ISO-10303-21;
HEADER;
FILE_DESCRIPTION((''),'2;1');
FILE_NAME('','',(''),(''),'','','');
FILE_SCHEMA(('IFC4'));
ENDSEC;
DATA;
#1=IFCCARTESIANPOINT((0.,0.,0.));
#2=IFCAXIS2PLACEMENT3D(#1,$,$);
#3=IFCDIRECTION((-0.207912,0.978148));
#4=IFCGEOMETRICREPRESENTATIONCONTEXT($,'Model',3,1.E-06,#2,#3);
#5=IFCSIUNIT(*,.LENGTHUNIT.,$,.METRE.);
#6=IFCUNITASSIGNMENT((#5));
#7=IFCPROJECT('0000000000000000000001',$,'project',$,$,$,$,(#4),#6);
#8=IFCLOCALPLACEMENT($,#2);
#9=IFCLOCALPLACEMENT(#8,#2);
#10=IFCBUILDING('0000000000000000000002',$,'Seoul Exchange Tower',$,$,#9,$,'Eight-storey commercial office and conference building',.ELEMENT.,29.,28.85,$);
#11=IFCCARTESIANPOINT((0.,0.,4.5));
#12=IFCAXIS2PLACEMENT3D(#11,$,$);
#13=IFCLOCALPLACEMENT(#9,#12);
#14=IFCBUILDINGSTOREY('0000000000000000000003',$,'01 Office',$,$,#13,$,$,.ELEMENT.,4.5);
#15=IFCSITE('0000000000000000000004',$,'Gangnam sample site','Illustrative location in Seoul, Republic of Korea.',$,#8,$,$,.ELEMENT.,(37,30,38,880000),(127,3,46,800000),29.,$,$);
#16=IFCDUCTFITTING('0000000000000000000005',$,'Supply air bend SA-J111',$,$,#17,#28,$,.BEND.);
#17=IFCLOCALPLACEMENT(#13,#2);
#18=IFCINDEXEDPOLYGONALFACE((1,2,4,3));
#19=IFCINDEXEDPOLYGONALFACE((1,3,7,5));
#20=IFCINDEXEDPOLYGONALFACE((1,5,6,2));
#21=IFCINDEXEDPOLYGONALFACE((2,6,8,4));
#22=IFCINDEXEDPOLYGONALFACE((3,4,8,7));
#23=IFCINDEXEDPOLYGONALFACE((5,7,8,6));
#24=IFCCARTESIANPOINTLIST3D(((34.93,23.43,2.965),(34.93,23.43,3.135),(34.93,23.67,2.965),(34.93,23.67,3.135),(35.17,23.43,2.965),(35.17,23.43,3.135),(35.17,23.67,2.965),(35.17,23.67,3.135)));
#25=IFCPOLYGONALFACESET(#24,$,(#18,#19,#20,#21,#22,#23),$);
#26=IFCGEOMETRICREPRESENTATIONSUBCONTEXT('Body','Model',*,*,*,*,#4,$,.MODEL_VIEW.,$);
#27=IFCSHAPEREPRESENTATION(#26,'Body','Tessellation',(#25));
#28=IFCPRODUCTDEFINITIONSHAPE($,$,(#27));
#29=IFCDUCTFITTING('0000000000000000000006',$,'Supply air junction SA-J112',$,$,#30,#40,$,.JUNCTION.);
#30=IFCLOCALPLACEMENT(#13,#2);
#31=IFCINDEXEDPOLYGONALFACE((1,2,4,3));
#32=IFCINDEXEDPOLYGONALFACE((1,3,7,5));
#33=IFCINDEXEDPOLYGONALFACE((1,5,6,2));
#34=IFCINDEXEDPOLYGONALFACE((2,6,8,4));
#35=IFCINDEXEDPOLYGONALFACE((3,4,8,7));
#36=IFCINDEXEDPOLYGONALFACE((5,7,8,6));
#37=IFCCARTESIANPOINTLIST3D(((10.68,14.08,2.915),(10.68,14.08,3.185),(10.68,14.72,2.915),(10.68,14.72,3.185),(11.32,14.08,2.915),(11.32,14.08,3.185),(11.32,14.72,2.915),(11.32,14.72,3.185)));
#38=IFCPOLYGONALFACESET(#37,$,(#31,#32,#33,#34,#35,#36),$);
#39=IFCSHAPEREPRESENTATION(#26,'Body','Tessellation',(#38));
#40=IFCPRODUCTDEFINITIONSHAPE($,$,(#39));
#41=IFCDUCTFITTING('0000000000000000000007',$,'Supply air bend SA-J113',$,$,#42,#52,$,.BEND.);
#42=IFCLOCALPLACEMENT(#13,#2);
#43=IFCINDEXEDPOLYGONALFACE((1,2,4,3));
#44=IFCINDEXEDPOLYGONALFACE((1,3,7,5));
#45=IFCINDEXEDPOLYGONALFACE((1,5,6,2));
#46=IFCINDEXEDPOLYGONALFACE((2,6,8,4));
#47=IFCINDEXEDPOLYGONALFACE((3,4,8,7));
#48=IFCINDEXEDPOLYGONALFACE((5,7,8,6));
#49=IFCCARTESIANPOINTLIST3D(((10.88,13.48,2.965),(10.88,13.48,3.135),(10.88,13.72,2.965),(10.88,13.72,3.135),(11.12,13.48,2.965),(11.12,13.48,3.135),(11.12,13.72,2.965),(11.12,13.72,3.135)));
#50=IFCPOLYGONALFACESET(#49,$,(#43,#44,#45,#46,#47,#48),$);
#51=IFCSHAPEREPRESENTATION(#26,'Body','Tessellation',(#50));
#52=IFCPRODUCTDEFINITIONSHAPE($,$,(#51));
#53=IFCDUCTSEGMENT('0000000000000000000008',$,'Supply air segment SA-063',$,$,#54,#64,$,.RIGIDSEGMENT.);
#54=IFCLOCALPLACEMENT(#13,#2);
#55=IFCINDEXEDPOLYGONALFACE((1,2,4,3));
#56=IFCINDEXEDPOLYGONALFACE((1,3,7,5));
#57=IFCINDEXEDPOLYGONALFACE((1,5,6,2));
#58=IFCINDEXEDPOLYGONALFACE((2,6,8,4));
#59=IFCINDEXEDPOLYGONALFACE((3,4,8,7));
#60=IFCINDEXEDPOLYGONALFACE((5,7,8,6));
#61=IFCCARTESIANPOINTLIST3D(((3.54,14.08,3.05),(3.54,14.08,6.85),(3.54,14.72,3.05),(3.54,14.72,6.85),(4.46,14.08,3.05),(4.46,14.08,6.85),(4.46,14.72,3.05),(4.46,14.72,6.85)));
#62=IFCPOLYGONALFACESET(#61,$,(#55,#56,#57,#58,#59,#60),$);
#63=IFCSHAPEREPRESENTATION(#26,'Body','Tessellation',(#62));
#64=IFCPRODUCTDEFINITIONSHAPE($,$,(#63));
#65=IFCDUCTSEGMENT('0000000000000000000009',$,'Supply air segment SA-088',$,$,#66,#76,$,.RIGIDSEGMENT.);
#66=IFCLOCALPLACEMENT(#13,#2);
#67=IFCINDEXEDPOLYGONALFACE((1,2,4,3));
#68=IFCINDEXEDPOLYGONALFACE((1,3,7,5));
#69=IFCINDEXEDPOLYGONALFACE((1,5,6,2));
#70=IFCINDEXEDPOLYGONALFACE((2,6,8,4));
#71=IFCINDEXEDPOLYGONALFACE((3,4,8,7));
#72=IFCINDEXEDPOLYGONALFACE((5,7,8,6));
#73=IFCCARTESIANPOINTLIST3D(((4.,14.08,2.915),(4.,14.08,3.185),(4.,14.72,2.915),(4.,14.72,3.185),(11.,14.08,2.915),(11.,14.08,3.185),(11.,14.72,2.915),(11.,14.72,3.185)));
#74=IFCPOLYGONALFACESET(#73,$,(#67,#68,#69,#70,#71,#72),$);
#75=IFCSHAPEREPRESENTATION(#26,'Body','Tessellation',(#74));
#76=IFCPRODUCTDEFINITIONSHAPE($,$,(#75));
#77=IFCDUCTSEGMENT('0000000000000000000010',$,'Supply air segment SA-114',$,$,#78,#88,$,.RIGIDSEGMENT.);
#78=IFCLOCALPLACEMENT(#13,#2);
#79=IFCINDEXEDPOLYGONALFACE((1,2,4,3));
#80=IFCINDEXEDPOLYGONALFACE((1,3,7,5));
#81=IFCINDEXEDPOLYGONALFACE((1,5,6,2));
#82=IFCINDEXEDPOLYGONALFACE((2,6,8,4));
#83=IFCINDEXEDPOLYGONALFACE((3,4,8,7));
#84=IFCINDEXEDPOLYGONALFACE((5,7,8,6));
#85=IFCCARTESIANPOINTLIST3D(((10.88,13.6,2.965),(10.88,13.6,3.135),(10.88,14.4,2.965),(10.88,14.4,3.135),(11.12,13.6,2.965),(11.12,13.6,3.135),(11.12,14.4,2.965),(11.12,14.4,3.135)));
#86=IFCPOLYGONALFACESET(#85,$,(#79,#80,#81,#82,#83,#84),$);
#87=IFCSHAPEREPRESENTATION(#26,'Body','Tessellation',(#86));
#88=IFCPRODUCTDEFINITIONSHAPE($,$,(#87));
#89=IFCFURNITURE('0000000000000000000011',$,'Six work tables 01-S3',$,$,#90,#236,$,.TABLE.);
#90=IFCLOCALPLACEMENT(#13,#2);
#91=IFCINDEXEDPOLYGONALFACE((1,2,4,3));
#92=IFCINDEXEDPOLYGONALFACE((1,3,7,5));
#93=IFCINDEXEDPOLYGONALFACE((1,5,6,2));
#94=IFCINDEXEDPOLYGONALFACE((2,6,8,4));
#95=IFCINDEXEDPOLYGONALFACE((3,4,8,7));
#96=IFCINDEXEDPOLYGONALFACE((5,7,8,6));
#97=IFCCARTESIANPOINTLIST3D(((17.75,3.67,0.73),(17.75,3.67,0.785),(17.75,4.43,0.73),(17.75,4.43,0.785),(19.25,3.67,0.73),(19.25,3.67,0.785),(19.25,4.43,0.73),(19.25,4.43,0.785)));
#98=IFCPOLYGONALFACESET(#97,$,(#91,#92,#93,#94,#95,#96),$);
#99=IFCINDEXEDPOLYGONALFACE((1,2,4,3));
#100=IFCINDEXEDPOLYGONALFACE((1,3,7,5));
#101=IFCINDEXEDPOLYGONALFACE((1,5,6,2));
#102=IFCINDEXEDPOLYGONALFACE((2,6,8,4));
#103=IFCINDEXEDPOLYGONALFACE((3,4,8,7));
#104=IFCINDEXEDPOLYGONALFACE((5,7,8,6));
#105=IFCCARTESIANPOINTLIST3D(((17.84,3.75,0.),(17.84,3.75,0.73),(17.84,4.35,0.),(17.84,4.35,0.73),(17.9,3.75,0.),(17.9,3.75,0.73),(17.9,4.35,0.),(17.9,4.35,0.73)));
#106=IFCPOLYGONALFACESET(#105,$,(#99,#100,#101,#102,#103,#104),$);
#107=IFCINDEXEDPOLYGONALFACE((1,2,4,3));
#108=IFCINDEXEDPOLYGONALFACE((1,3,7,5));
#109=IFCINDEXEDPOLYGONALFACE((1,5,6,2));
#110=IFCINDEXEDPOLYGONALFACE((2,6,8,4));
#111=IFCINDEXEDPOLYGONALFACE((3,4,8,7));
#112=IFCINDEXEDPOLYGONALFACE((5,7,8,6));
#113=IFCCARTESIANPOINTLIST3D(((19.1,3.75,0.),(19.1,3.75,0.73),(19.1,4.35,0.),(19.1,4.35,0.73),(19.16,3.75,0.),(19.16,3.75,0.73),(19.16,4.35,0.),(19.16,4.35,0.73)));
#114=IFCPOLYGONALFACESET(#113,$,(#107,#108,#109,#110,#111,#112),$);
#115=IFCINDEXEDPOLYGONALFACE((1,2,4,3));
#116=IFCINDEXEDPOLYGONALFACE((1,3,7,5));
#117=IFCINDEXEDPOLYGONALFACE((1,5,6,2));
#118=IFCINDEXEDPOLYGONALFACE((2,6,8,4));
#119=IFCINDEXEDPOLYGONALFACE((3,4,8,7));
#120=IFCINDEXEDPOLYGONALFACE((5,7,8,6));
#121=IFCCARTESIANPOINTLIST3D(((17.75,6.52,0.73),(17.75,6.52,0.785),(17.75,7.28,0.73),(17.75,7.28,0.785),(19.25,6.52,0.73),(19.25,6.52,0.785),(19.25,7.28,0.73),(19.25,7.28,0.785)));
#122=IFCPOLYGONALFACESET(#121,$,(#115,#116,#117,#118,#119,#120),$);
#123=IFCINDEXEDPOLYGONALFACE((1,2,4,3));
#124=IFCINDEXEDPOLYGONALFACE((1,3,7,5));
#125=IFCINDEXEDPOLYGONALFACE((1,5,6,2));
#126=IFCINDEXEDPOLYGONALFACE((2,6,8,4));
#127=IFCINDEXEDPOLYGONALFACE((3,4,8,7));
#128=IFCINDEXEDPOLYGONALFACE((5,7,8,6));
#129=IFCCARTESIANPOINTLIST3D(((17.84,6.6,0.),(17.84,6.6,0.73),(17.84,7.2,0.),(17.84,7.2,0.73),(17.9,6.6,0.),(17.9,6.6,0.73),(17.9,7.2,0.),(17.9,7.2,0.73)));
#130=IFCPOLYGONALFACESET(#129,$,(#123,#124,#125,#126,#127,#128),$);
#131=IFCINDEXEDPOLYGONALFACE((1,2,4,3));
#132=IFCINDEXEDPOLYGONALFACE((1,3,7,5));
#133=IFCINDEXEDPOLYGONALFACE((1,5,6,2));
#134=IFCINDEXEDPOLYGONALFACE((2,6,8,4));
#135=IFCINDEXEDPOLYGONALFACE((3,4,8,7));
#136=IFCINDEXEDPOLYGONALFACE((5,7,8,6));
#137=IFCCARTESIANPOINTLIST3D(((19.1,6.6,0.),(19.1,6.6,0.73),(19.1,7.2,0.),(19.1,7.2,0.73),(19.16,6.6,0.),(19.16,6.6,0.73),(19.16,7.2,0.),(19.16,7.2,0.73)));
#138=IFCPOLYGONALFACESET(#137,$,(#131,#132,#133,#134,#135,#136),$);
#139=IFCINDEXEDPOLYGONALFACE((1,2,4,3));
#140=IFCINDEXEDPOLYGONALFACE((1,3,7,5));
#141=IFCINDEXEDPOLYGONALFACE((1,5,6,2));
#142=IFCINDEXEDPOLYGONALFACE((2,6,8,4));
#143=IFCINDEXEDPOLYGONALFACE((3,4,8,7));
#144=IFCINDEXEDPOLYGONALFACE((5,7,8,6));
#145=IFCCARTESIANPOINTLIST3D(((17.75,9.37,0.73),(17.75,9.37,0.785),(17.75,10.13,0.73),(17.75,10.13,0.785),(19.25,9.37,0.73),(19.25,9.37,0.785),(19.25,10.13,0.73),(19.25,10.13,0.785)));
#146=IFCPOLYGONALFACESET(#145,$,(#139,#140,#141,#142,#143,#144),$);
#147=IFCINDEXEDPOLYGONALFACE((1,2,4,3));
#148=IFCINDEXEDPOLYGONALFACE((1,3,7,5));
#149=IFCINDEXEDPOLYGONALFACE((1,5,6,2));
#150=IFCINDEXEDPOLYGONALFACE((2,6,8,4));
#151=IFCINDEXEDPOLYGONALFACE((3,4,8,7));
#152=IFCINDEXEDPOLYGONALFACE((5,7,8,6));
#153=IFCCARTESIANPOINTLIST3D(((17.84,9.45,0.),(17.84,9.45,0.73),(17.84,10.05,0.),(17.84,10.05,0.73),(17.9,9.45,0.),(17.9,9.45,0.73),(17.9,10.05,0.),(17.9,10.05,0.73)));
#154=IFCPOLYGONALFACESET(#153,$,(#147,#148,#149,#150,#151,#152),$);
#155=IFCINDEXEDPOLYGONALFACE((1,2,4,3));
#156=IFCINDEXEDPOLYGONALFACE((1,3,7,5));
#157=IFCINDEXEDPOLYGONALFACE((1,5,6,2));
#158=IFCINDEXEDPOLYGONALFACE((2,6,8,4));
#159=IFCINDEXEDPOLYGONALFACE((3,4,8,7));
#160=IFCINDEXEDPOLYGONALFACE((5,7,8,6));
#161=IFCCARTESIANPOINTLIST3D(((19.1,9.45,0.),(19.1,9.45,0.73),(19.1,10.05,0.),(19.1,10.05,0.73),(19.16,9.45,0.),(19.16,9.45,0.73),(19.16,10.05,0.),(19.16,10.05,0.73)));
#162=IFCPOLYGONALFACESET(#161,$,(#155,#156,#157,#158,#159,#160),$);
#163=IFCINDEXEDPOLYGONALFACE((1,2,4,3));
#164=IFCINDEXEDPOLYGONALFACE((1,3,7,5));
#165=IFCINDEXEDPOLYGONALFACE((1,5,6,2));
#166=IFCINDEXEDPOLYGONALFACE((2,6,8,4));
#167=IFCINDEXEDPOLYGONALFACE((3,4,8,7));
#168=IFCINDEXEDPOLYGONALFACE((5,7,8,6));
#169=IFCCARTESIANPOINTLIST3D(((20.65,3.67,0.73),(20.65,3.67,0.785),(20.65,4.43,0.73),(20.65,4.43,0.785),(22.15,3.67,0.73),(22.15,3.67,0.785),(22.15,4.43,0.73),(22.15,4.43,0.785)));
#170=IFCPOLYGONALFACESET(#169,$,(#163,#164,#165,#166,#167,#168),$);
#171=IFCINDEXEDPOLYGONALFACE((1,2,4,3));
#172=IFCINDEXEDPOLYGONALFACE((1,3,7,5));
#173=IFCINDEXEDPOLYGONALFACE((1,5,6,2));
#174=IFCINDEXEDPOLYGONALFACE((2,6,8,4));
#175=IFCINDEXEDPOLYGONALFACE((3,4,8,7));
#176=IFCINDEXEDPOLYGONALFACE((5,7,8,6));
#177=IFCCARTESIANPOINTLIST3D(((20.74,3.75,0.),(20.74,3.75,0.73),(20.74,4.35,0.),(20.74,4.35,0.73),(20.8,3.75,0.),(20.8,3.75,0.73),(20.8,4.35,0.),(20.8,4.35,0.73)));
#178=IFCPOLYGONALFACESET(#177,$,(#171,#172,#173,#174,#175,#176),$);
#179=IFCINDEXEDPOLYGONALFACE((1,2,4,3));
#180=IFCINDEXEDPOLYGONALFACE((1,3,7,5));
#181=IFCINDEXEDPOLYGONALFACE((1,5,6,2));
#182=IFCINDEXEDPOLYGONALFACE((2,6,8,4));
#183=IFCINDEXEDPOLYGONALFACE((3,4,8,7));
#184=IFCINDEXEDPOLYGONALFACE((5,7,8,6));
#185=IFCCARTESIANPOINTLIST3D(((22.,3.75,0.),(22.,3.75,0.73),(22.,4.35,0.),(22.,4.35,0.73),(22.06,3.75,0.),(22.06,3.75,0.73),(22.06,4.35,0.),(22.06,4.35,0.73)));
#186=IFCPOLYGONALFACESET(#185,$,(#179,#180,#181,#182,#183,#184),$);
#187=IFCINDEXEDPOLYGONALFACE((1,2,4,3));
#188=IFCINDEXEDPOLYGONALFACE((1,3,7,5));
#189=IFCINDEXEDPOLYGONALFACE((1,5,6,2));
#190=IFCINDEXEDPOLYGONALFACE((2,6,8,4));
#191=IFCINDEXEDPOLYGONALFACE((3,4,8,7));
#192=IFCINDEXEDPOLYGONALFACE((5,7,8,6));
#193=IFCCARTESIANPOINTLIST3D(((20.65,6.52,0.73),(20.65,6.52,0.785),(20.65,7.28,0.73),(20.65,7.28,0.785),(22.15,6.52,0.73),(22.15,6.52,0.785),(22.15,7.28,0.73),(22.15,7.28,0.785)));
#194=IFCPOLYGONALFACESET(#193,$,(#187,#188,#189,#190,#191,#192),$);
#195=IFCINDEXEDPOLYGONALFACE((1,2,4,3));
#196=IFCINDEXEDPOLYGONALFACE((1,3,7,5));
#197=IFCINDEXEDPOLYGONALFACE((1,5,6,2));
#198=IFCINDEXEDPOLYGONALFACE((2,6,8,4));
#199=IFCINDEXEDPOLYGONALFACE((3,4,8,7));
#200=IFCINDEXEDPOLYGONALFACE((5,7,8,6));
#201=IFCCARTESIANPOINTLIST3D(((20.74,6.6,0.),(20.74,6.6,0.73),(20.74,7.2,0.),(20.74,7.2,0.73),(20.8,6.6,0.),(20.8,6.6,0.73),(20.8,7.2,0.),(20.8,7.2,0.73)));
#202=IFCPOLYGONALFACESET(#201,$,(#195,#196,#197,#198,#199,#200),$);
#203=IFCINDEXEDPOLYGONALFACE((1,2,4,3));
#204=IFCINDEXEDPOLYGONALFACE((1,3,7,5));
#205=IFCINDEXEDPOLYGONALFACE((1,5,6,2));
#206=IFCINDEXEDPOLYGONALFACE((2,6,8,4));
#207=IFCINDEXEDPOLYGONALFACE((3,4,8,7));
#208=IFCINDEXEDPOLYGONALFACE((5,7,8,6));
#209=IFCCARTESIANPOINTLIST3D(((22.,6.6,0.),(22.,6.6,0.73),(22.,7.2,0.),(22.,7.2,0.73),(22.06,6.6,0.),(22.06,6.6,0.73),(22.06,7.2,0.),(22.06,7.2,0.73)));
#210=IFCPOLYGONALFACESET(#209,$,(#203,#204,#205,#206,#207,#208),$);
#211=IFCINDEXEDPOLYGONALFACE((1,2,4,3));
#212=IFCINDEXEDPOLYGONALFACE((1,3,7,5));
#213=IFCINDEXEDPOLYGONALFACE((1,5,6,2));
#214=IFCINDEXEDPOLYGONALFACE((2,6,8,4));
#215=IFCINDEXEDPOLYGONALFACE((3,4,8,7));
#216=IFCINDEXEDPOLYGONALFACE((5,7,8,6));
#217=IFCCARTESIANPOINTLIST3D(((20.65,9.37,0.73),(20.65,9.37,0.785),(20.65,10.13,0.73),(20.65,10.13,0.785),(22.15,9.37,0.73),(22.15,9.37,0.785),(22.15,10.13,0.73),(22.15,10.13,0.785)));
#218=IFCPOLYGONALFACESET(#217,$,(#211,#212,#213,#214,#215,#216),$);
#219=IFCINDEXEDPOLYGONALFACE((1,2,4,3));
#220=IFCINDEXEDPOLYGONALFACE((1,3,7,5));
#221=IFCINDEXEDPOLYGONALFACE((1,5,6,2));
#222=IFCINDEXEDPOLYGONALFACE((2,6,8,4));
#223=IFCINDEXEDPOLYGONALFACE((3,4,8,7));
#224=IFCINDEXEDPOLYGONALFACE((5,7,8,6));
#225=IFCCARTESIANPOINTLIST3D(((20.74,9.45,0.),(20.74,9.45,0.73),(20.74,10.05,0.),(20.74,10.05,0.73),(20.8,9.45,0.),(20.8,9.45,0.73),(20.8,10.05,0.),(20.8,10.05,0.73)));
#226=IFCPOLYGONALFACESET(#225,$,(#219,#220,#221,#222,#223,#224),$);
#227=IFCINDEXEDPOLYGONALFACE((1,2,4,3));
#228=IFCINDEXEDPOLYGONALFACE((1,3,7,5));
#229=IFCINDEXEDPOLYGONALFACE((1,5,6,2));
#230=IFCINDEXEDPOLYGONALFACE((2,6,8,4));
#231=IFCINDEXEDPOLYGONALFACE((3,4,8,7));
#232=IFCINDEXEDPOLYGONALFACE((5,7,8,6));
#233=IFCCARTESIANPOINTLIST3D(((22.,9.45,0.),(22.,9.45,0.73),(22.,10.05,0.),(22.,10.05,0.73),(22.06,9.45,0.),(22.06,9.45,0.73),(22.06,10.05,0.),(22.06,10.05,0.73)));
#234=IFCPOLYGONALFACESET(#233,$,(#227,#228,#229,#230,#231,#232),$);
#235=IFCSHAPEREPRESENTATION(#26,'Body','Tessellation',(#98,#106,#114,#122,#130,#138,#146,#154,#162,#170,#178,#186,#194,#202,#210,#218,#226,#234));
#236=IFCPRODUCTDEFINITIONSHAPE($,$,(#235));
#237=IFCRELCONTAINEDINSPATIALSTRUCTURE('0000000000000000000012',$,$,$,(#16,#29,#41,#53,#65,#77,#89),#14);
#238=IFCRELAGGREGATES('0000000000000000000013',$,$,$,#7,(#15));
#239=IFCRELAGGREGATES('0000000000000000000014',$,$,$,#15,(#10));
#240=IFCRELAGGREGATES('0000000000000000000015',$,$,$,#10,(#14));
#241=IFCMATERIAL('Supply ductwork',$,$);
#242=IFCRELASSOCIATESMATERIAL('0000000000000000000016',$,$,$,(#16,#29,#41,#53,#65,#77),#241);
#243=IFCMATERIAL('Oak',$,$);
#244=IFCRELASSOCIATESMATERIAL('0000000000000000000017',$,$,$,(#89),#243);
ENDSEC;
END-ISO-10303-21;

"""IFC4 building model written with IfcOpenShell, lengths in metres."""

from ifc_helpers import new_model, si_unit, direction, frame, frame_2d, origin, place, context, subcontext, project, spatial, rectangle, extrude, material, element, save


model = new_model("IFC4")

# Units and contexts
model_context = context("Model", 3, precision=1e-06, world=origin(), true_north=direction((-0.207912, 0.978148)))
body_context = subcontext(model_context, "Body", "Model", "MODEL_VIEW")
ifc_project = project(units=[si_unit("LENGTHUNIT", "METRE")], contexts=[model_context])

# Site, building, storey
site_placement = place(None, origin())
site = spatial("IfcSite", under=ifc_project, at=site_placement, Name="Gangnam sample site", Description="Illustrative location in Seoul, Republic of Korea.", CompositionType="ELEMENT", RefLatitude=(37, 30, 38, 880000), RefLongitude=(127, 3, 46, 800000), RefElevation=29.0)
building_placement = place(site_placement, origin())
building = spatial("IfcBuilding", under=site, at=building_placement, Name="Seoul Exchange Tower", LongName="Eight-storey commercial office and conference building", CompositionType="ELEMENT", ElevationOfRefHeight=29.0, ElevationOfTerrain=28.85)
storey_placement = place(building_placement, frame((0.0, 0.0, 4.5)))
storey = spatial("IfcBuildingStorey", under=building, at=storey_placement, Name="01 Office", CompositionType="ELEMENT", Elevation=4.5)

# Shared definitions
placement = place(storey_placement, origin())

# Duct fittings
ifc_material_1 = material(Name="Supply ductwork")
element("IfcDuctFitting", 1, at=placement, inside=storey, material=ifc_material_1, Name="Supply air bend SA-J111", PredefinedType="BEND", context=body_context, shape_type="SweptSolid", body=[
    extrude(rectangle(XDim=0.24, YDim=0.24, at=frame_2d((0.12, 0.12))), frame((34.93, 23.43, 2.965)), (0.0, 0.0, 1.0), 0.17),
])
element("IfcDuctFitting", 2, at=placement, inside=storey, material=ifc_material_1, Name="Supply air junction SA-J112", PredefinedType="JUNCTION", context=body_context, shape_type="SweptSolid", body=[
    extrude(rectangle(XDim=0.64, YDim=0.64, at=frame_2d((0.32, 0.32))), frame((10.68, 14.08, 2.915)), (0.0, 0.0, 1.0), 0.27),
])
element("IfcDuctFitting", 3, at=placement, inside=storey, material=ifc_material_1, Name="Supply air bend SA-J113", PredefinedType="BEND", context=body_context, shape_type="SweptSolid", body=[
    extrude(rectangle(XDim=0.24, YDim=0.24, at=frame_2d((0.12, 0.12))), frame((10.88, 13.48, 2.965)), (0.0, 0.0, 1.0), 0.17),
])

# Duct segments
element("IfcDuctSegment", 4, at=placement, inside=storey, material=ifc_material_1, Name="Supply air segment SA-063", PredefinedType="RIGIDSEGMENT", context=body_context, shape_type="SweptSolid", body=[
    extrude(rectangle(XDim=0.92, YDim=0.64), frame((4.0, 14.4, 6.85), z_axis=(0.0, 0.0, -1.0), x_axis=(1.0, 0.0, 0.0)), (0.0, 0.0, 1.0), 3.8),
])
element("IfcDuctSegment", 5, at=placement, inside=storey, material=ifc_material_1, Name="Supply air segment SA-088", PredefinedType="RIGIDSEGMENT", context=body_context, shape_type="SweptSolid", body=[
    extrude(rectangle(XDim=0.64, YDim=0.27), frame((4.0, 14.4, 3.05), z_axis=(1.0, 0.0, 0.0), x_axis=(0.0, 1.0, 0.0)), (0.0, 0.0, 1.0), 7.0),
])
element("IfcDuctSegment", 6, at=placement, inside=storey, material=ifc_material_1, Name="Supply air segment SA-114", PredefinedType="RIGIDSEGMENT", context=body_context, shape_type="SweptSolid", body=[
    extrude(rectangle(XDim=0.24, YDim=0.17), frame((11.0, 14.4, 3.05), z_axis=(0.0, -1.0, 0.0), x_axis=(1.0, 0.0, 0.0)), (0.0, 0.0, 1.0), 0.8),
])

# Furniture
ifc_material_2 = material(Name="Oak")
element("IfcFurniture", 7, at=placement, inside=storey, material=ifc_material_2, Name="Six work tables 01-S3", PredefinedType="TABLE", context=body_context, shape_type="SweptSolid", body=[
    extrude(rectangle(XDim=1.5, YDim=0.76, at=frame_2d((0.75, 0.38))), frame((17.75, 3.67, 0.73)), (0.0, 0.0, 1.0), 0.055),
    extrude(rectangle(XDim=0.06, YDim=0.6, at=frame_2d((0.03, 0.3))), frame((17.84, 3.75, 0.0)), (0.0, 0.0, 1.0), 0.73),
    extrude(rectangle(XDim=0.06, YDim=0.6, at=frame_2d((0.03, 0.3))), frame((19.1, 3.75, 0.0)), (0.0, 0.0, 1.0), 0.73),
    extrude(rectangle(XDim=1.5, YDim=0.76, at=frame_2d((0.75, 0.38))), frame((17.75, 6.52, 0.73)), (0.0, 0.0, 1.0), 0.055),
    extrude(rectangle(XDim=0.06, YDim=0.6, at=frame_2d((0.03, 0.3))), frame((17.84, 6.6, 0.0)), (0.0, 0.0, 1.0), 0.73),
    extrude(rectangle(XDim=0.06, YDim=0.6, at=frame_2d((0.03, 0.3))), frame((19.1, 6.6, 0.0)), (0.0, 0.0, 1.0), 0.73),
    extrude(rectangle(XDim=1.5, YDim=0.76, at=frame_2d((0.75, 0.38))), frame((17.75, 9.37, 0.73)), (0.0, 0.0, 1.0), 0.055),
    extrude(rectangle(XDim=0.06, YDim=0.6, at=frame_2d((0.03, 0.3))), frame((17.84, 9.45, 0.0)), (0.0, 0.0, 1.0), 0.73),
    extrude(rectangle(XDim=0.06, YDim=0.6, at=frame_2d((0.03, 0.3))), frame((19.1, 9.45, 0.0)), (0.0, 0.0, 1.0), 0.73),
    extrude(rectangle(XDim=1.5, YDim=0.76, at=frame_2d((0.75, 0.38))), frame((20.65, 3.67, 0.73)), (0.0, 0.0, 1.0), 0.055),
    extrude(rectangle(XDim=0.06, YDim=0.6, at=frame_2d((0.03, 0.3))), frame((20.74, 3.75, 0.0)), (0.0, 0.0, 1.0), 0.73),
    extrude(rectangle(XDim=0.06, YDim=0.6, at=frame_2d((0.03, 0.3))), frame((22.0, 3.75, 0.0)), (0.0, 0.0, 1.0), 0.73),
    extrude(rectangle(XDim=1.5, YDim=0.76, at=frame_2d((0.75, 0.38))), frame((20.65, 6.52, 0.73)), (0.0, 0.0, 1.0), 0.055),
    extrude(rectangle(XDim=0.06, YDim=0.6, at=frame_2d((0.03, 0.3))), frame((20.74, 6.6, 0.0)), (0.0, 0.0, 1.0), 0.73),
    extrude(rectangle(XDim=0.06, YDim=0.6, at=frame_2d((0.03, 0.3))), frame((22.0, 6.6, 0.0)), (0.0, 0.0, 1.0), 0.73),
    extrude(rectangle(XDim=1.5, YDim=0.76, at=frame_2d((0.75, 0.38))), frame((20.65, 9.37, 0.73)), (0.0, 0.0, 1.0), 0.055),
    extrude(rectangle(XDim=0.06, YDim=0.6, at=frame_2d((0.03, 0.3))), frame((20.74, 9.45, 0.0)), (0.0, 0.0, 1.0), 0.73),
    extrude(rectangle(XDim=0.06, YDim=0.6, at=frame_2d((0.03, 0.3))), frame((22.0, 9.45, 0.0)), (0.0, 0.0, 1.0), 0.73),
])

save(model, "model.ifc")
